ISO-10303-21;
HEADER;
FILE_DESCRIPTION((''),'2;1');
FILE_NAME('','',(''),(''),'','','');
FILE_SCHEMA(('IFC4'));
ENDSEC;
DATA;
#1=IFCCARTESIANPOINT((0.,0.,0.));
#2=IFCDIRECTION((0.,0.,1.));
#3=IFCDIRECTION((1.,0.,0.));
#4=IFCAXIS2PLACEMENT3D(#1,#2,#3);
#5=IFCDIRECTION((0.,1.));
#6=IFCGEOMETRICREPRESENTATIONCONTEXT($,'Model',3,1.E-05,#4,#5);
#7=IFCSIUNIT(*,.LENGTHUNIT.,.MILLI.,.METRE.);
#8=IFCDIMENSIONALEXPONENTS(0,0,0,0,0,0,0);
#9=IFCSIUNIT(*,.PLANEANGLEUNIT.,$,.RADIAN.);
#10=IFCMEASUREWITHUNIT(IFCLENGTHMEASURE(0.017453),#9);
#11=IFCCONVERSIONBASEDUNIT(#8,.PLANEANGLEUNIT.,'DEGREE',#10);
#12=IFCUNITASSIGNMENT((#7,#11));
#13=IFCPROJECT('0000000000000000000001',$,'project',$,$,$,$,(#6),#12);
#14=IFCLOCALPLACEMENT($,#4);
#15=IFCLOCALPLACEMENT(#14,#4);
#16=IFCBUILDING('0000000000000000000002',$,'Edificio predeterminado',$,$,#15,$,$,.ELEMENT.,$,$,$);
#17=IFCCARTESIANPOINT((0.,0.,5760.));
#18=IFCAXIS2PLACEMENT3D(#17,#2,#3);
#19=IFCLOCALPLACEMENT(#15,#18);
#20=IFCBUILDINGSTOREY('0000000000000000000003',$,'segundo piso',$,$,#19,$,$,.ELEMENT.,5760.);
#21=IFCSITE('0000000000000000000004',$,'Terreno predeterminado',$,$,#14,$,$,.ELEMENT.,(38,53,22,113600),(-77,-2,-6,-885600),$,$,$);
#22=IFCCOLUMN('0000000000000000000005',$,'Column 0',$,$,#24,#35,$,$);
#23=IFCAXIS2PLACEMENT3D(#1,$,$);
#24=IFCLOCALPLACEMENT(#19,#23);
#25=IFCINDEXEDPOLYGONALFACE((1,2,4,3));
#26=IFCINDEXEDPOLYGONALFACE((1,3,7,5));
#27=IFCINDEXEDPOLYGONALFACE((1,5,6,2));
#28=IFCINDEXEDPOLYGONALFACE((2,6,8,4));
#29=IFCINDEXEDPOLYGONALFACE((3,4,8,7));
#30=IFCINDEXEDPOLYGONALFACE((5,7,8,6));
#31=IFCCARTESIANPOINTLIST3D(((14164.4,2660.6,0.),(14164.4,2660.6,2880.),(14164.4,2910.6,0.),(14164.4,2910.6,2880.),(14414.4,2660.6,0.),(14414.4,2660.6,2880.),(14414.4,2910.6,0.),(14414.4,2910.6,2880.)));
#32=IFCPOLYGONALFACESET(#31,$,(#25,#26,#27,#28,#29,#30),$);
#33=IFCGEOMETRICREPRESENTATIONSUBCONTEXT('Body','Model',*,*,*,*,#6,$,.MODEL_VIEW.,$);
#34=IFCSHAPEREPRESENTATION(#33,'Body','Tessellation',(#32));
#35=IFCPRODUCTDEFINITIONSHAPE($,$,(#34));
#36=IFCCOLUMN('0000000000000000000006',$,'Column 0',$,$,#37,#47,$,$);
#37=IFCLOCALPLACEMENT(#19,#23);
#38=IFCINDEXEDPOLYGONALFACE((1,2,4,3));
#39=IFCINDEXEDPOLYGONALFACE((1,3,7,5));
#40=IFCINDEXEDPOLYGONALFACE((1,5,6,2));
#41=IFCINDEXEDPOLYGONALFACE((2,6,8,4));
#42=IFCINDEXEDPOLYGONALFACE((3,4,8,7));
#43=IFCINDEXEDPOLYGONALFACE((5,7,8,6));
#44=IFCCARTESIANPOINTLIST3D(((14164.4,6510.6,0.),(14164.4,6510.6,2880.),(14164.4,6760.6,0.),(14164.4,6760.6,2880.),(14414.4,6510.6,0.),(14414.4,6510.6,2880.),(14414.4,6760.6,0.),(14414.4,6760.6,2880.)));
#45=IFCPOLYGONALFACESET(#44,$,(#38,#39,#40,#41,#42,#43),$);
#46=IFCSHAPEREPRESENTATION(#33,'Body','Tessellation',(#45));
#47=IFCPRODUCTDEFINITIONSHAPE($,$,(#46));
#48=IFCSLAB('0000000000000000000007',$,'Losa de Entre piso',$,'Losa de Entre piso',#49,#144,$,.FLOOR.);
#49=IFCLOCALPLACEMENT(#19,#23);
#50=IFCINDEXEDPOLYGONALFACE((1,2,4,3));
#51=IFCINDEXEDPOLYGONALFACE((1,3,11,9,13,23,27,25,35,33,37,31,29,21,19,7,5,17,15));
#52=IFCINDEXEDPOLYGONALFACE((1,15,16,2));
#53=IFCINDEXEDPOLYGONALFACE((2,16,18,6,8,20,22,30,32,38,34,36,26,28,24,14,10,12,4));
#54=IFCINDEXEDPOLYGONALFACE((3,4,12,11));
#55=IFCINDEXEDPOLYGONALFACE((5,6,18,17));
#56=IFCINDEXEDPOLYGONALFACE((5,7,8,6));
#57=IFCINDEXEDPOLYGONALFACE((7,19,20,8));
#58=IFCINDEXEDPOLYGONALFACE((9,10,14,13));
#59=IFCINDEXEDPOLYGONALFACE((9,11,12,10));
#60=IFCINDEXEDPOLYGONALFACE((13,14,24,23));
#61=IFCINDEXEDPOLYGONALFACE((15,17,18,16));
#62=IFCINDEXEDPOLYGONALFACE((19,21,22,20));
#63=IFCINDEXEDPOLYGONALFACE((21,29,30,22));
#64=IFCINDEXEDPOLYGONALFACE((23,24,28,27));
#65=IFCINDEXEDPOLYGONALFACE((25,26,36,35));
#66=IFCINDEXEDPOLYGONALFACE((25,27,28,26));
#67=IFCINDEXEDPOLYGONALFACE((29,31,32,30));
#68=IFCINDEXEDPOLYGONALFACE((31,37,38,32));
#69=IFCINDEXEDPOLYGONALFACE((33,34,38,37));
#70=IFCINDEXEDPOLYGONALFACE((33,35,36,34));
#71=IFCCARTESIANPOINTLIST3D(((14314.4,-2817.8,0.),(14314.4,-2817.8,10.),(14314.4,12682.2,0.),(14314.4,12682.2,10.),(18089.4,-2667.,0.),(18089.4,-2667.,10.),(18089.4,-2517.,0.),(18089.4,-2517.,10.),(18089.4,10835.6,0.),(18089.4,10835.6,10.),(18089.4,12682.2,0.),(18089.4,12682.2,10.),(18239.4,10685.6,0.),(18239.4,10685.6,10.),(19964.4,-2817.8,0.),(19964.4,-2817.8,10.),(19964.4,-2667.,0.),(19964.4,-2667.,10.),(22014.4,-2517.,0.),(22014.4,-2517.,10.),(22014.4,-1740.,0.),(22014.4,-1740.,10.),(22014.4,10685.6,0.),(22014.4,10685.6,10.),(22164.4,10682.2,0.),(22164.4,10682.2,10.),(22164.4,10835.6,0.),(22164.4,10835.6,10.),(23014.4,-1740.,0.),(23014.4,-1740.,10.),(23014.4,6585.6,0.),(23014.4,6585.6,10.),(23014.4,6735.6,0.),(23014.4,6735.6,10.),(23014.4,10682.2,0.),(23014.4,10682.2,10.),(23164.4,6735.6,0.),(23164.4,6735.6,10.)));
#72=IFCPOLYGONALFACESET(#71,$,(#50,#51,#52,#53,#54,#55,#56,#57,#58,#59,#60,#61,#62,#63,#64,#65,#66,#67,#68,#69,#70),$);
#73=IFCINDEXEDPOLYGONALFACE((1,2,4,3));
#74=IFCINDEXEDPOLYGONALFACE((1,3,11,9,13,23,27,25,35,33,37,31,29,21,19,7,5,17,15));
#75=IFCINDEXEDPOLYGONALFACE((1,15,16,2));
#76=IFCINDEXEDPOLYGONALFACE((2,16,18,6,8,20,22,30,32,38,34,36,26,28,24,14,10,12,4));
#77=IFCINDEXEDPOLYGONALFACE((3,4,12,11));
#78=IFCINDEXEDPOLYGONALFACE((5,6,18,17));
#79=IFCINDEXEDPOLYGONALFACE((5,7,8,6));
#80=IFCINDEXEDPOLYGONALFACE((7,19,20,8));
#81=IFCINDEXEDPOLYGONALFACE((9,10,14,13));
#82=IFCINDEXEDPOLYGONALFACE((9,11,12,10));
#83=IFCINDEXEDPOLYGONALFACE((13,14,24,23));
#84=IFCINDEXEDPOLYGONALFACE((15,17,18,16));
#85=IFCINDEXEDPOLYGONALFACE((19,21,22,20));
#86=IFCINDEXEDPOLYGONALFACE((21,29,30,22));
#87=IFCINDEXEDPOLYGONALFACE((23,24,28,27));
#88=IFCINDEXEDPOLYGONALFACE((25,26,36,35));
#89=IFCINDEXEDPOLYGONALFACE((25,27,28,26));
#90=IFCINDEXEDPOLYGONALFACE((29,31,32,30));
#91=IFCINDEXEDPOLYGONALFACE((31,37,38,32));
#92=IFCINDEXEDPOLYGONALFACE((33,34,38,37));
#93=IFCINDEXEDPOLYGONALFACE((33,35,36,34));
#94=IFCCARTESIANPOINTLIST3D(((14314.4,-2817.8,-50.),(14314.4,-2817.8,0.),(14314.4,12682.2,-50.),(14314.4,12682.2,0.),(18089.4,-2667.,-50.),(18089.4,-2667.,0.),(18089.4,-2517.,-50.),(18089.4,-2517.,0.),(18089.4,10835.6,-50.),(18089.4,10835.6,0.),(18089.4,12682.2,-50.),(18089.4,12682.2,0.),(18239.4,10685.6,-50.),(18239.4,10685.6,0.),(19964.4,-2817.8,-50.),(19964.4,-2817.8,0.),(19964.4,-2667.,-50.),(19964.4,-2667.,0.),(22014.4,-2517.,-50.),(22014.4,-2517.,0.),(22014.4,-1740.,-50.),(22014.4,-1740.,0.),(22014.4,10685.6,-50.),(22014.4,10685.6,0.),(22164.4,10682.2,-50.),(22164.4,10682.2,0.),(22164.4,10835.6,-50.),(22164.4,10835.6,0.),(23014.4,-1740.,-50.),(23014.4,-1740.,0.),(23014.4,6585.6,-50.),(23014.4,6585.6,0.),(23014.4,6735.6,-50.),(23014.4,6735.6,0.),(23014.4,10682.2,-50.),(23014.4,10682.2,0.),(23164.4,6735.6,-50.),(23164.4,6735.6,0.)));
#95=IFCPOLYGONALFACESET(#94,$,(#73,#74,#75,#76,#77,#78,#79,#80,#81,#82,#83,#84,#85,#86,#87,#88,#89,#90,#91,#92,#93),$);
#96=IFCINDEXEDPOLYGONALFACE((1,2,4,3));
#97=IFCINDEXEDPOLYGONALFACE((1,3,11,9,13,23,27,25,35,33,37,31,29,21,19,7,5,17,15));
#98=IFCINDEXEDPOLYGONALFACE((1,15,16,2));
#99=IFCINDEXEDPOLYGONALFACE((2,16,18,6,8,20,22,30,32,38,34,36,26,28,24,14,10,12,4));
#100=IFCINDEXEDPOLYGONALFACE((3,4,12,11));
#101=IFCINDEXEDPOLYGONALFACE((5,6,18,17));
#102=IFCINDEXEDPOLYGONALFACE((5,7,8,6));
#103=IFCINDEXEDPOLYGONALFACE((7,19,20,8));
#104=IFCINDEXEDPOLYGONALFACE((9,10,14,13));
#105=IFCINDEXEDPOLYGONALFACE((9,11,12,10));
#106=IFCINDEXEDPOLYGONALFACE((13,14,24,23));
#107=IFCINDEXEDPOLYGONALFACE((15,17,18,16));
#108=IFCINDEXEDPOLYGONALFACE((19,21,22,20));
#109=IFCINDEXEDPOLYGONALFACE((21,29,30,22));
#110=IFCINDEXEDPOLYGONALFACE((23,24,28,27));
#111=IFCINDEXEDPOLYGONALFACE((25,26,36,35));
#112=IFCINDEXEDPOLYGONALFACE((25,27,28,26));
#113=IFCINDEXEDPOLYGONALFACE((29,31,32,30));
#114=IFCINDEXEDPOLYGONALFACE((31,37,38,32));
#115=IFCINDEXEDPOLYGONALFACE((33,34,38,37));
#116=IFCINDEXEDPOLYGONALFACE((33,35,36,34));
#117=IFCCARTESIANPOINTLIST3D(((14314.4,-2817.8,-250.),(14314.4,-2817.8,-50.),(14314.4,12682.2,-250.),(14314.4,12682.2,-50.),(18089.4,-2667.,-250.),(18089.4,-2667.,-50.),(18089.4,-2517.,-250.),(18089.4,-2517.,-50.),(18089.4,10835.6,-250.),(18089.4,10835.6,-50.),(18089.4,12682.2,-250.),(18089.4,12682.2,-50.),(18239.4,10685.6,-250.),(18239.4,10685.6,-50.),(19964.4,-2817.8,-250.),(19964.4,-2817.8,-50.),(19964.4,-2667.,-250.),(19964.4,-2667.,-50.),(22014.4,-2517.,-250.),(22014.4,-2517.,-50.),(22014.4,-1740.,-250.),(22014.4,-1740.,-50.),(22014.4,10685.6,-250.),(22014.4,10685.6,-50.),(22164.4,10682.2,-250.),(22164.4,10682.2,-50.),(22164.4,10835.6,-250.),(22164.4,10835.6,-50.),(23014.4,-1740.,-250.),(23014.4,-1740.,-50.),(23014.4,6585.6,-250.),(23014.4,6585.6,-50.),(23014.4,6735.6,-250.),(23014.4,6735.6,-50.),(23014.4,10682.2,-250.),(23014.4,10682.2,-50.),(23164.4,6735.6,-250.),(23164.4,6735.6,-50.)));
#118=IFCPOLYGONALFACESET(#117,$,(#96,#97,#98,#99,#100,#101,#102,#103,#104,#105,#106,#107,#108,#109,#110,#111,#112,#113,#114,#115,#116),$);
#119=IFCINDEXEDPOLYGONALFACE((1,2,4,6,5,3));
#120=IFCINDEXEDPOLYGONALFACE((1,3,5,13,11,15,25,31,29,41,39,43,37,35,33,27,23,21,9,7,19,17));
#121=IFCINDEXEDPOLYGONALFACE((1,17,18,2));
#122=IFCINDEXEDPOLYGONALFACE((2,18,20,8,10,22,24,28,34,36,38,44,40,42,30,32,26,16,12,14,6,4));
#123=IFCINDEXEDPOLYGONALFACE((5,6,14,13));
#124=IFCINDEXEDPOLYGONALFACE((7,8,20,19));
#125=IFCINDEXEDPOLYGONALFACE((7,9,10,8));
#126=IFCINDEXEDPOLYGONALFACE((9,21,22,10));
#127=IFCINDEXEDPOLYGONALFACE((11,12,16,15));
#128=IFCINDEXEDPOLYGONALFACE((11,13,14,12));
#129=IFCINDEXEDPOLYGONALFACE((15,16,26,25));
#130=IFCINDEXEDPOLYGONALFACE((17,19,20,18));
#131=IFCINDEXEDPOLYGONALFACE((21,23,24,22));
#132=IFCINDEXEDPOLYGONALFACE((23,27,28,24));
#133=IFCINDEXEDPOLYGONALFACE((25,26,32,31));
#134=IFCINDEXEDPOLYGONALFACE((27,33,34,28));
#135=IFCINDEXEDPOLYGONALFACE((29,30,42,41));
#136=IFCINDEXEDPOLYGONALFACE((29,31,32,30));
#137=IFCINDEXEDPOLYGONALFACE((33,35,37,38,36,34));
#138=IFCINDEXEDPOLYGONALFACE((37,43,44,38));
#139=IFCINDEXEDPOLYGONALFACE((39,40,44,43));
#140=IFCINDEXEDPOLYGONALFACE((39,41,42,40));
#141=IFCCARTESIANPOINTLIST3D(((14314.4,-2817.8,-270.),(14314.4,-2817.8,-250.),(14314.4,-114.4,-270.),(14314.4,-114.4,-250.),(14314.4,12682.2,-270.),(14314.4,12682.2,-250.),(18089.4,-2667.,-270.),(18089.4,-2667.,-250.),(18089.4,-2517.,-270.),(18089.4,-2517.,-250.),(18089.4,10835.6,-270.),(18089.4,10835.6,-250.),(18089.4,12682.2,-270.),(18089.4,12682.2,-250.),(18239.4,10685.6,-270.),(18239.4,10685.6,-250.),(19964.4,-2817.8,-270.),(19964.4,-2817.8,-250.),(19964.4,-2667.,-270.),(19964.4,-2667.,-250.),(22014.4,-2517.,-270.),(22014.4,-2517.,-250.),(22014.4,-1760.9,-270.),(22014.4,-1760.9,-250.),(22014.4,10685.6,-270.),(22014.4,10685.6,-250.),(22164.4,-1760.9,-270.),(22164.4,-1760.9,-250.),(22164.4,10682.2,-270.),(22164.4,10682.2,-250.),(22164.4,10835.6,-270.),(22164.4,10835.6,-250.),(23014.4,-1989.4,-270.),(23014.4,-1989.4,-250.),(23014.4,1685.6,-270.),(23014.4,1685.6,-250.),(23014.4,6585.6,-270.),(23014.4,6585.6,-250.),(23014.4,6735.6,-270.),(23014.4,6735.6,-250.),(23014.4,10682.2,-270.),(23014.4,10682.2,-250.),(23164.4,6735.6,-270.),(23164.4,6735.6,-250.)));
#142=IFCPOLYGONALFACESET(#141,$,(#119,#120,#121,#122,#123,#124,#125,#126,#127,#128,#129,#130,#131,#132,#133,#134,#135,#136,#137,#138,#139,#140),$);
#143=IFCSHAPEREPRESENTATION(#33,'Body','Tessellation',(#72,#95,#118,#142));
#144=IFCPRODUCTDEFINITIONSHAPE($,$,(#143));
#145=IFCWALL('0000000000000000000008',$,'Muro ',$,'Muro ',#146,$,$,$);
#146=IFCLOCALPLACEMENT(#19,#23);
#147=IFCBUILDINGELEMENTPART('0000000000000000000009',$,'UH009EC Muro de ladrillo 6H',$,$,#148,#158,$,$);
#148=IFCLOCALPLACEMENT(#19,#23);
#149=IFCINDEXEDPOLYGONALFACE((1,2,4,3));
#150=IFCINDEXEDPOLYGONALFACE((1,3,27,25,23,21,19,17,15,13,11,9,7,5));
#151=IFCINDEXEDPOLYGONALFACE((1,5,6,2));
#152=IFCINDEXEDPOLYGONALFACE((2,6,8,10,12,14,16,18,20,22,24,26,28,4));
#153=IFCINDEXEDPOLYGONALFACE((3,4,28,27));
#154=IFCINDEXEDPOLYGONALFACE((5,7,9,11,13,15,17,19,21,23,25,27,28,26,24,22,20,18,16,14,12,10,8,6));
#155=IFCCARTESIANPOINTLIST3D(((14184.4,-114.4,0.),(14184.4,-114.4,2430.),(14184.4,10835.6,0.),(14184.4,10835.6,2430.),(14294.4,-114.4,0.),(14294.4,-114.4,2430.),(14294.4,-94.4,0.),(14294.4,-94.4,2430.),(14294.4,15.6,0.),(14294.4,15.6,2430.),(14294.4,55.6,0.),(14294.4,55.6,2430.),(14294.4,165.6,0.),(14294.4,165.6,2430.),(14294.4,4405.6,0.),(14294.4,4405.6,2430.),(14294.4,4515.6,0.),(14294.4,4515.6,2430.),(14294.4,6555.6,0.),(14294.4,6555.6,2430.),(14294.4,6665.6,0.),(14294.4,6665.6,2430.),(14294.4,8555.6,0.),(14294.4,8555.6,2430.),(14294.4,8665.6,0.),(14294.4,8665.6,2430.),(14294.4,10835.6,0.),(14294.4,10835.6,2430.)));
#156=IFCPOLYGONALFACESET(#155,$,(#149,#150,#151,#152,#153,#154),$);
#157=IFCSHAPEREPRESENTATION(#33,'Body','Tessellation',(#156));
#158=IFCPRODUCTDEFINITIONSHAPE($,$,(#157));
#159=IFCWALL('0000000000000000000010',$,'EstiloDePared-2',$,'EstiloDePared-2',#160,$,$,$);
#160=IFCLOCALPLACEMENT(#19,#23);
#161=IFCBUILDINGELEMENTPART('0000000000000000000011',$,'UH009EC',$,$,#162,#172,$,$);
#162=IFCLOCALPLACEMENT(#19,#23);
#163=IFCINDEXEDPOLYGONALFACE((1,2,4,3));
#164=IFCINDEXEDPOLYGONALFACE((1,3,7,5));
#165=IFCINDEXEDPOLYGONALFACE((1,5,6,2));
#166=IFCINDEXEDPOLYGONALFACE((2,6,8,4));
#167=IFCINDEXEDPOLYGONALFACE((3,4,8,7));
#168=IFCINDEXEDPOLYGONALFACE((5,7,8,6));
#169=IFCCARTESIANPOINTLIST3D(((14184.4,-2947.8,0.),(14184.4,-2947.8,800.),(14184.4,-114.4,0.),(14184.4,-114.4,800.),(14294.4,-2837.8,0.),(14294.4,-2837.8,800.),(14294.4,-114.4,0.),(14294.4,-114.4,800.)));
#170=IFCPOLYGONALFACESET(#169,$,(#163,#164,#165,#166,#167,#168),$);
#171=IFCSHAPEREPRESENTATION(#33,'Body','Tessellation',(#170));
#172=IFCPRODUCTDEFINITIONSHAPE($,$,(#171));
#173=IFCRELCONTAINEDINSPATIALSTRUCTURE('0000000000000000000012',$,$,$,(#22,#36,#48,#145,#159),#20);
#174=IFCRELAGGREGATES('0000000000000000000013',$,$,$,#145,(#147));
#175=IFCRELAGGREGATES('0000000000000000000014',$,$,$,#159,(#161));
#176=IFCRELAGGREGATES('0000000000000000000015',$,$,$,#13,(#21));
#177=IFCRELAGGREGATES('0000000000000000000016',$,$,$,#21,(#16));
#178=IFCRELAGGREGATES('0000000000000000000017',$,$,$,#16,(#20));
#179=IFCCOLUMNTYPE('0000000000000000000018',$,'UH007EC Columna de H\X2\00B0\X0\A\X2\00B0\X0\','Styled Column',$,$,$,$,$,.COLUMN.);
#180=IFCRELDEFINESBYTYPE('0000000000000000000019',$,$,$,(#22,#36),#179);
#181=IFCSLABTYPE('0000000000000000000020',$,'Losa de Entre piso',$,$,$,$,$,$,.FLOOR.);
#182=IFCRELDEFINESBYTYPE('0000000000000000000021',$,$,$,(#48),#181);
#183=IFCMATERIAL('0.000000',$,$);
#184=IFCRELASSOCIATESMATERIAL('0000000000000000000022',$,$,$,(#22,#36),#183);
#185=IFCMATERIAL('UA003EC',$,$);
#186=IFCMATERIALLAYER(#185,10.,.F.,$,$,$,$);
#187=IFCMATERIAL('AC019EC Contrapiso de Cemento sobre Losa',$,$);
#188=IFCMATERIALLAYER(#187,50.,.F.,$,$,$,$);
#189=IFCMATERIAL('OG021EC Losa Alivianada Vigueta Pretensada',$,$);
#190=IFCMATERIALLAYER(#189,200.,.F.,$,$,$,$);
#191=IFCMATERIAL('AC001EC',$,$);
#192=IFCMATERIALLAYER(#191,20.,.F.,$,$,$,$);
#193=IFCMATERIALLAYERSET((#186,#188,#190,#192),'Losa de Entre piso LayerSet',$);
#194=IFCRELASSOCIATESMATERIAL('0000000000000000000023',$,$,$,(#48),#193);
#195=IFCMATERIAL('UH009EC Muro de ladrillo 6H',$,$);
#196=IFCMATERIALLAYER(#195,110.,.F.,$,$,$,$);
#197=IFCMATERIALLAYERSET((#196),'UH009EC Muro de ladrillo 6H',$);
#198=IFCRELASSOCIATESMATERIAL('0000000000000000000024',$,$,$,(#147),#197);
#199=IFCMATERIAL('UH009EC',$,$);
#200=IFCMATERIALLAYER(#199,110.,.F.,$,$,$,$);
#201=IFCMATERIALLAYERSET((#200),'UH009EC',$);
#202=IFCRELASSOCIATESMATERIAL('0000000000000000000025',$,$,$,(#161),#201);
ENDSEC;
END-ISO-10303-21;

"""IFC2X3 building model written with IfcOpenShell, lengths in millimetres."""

from ifc_helpers import new_model, entity, si_unit, converted_unit, direction, frame, origin_with_axes, place, context, subcontext, project, spatial, polyline, outline, extrude, material, layer, layer_set, layer_usage, type_object, element, aggregate, save


model = new_model("IFC2X3")

# Units and contexts
model_context = context("Model", 3, precision=1e-05, world=origin_with_axes(), true_north=direction((0.0, 1.0)))
body_context = subcontext(model_context, "Body", "Model", "MODEL_VIEW")
ifc_project = project(units=[si_unit("LENGTHUNIT", "METRE", prefix="MILLI"), converted_unit("PLANEANGLEUNIT", "DEGREE", entity("IfcLengthMeasure", 0.017453), si_unit("PLANEANGLEUNIT", "RADIAN"), dimensions=[0, 0, 0, 0, 0, 0, 0])], contexts=[model_context])

# Site, building, storey
site_placement = place(None, origin_with_axes())
site = spatial("IfcSite", under=ifc_project, at=site_placement, Name="Terreno predeterminado", CompositionType="ELEMENT", RefLatitude=(38, 53, 22, 113600), RefLongitude=(-77, -2, -6, -885600))
building_placement = place(site_placement, origin_with_axes())
building = spatial("IfcBuilding", under=site, at=building_placement, Name="Edificio predeterminado", CompositionType="ELEMENT")
storey_placement = place(building_placement, frame((0.0, 0.0, 5760.0), z_axis=(0.0, 0.0, 1.0), x_axis=(1.0, 0.0, 0.0)))
storey = spatial("IfcBuildingStorey", under=building, at=storey_placement, Name="segundo piso", CompositionType="ELEMENT", Elevation=5760.0)

# Columns
ifc_material_1 = material(Name="0.000000")
column_type = type_object("IfcColumnType", Name="UH007EC Columna de H°A°", Description="Styled Column", PredefinedType="COLUMN")
for number, where, z_axis, x_axis, name in (
    (1, (14289.4, 2785.6, 0.0), (0.0, 0.0, 1.0), (1.0, 0.0, 0.0), "Column 0"),
    (2, (14289.4, 6635.6, 0.0), (0.0, 0.0, 1.0), (1.0, 0.0, 0.0), "Column 0"),
):
    element("IfcColumn", number, at=place(storey_placement, frame(where, z_axis=z_axis, x_axis=x_axis)), inside=storey, type_object=column_type, material=ifc_material_1, Name=name, context=body_context, shape_type="SweptSolid", body=[
        extrude(outline(polyline([(-125.0, -125.0), (125.0, -125.0), (125.0, 125.0), (-125.0, 125.0), (-125.0, -125.0)])), origin_with_axes(), (0.0, 0.0, 1.0), 2880.0),
    ])

# Slab
ifc_material_2 = material(Name="UA003EC")
ifc_layer_1 = layer(ifc_material_2, 10.0, ventilated=False)
ifc_material_3 = material(Name="AC019EC Contrapiso de Cemento sobre Losa")
ifc_layer_2 = layer(ifc_material_3, 50.0, ventilated=False)
ifc_material_4 = material(Name="OG021EC Losa Alivianada Vigueta Pretensada")
ifc_layer_3 = layer(ifc_material_4, 200.0, ventilated=False)
ifc_material_5 = material(Name="AC001EC")
ifc_layer_4 = layer(ifc_material_5, 20.0, ventilated=False)
ifc_layer_set_1 = layer_set([ifc_layer_1, ifc_layer_2, ifc_layer_3, ifc_layer_4], Name="Losa de Entre piso LayerSet")
ifc_layer_usage_1 = layer_usage(ifc_layer_set_1, "AXIS3", "POSITIVE", 0.0)
slab_type = type_object("IfcSlabType", Name="Losa de Entre piso", PredefinedType="FLOOR")
slab_placement = place(storey_placement, frame((0.0, 0.0, -5760.0), z_axis=(0.0, 0.0, 1.0), x_axis=(1.0, 0.0, 0.0)))
element("IfcSlab", 3, at=slab_placement, inside=storey, type_object=slab_type, material=ifc_layer_usage_1, Name="Losa de Entre piso", ObjectType="Losa de Entre piso", PredefinedType="FLOOR", context=body_context, shape_type="SweptSolid", body=[
    extrude(outline(polyline([(0.0, -777.0), (-1000.0, -777.0), (-1000.0, -9102.6), (-1150.0, -9252.6), (-1000.0, -9252.6), (-1000.0, -13199.1), (-150.0, -13199.1), (-150.0, -13352.6), (0.0, -13202.6), (3775.0, -13202.6), (3925.0, -13352.6), (3925.0, -15199.1), (7700.0, -15199.1), (7700.0, 300.9), (2050.0, 300.9), (2050.0, 150.0), (3925.0, 150.0), (3925.0, 0.0), (0.0, 0.0), (0.0, -777.0)])), frame((22014.4, -2517.0, 5760.0), z_axis=(0.0, 0.0, 1.0), x_axis=(-1.0, 0.0, 0.0)), (0.0, 0.0, 1.0), 10.0),
    extrude(outline(polyline([(0.0, -777.0), (-1000.0, -777.0), (-1000.0, -9102.6), (-1150.0, -9252.6), (-1000.0, -9252.6), (-1000.0, -13199.1), (-150.0, -13199.1), (-150.0, -13352.6), (0.0, -13202.6), (3775.0, -13202.6), (3925.0, -13352.6), (3925.0, -15199.1), (7700.0, -15199.1), (7700.0, 300.9), (2050.0, 300.9), (2050.0, 150.0), (3925.0, 150.0), (3925.0, 0.0), (0.0, 0.0), (0.0, -777.0)])), frame((22014.4, -2517.0, 5710.0), z_axis=(0.0, 0.0, 1.0), x_axis=(-1.0, 0.0, 0.0)), (0.0, 0.0, 1.0), 50.0),
    extrude(outline(polyline([(0.0, -777.0), (-1000.0, -777.0), (-1000.0, -9102.6), (-1150.0, -9252.6), (-1000.0, -9252.6), (-1000.0, -13199.1), (-150.0, -13199.1), (-150.0, -13352.6), (0.0, -13202.6), (3775.0, -13202.6), (3925.0, -13352.6), (3925.0, -15199.1), (7700.0, -15199.1), (7700.0, 300.9), (2050.0, 300.9), (2050.0, 150.0), (3925.0, 150.0), (3925.0, 0.0), (0.0, 0.0), (0.0, -777.0)])), frame((22014.4, -2517.0, 5510.0), z_axis=(0.0, 0.0, 1.0), x_axis=(-1.0, 0.0, 0.0)), (0.0, 0.0, 1.0), 200.0),
    extrude(outline(polyline([(-1305.7, 1305.7), (-3975.1, -1363.6), (5073.5, -10412.1), (6985.1, -12323.8), (10980.3, -8328.6), (10873.6, -8221.9), (9547.8, -9547.8), (9441.7, -9441.7), (12217.1, -6666.3), (11682.5, -6131.7), (11788.6, -6025.7), (12551.1, -5586.1), (9952.5, -2987.5), (6487.7, 477.3), (6487.7, 689.4), (6381.6, 583.4), (3591.0, 3374.0), (2990.0, 2773.0), (2881.5, 2881.5), (2881.5, 2669.3), (212.1, 0.0), (0.0, 0.0), (-1305.7, 1305.7)])), frame((18089.4, 10835.6, 5490.0), z_axis=(0.0, 0.0, 1.0), x_axis=(0.707107, -0.707107, 0.0)), (0.0, 0.0, 1.0), 20.0),
])

# Walls, building element parts
wall_1_placement = place(storey_placement, frame((14239.4, 10835.6, 0.0), z_axis=(0.0, 0.0, 1.0), x_axis=(0.0, -1.0, 0.0)))
wall_1 = element("IfcWall", 4, at=wall_1_placement, inside=storey, Name="Muro ", ObjectType="Muro ")
ifc_material_6 = material(Name="UH009EC Muro de ladrillo 6H")
ifc_layer_5 = layer(ifc_material_6, 110.0, ventilated=False)
ifc_layer_set_2 = layer_set([ifc_layer_5], Name="UH009EC Muro de ladrillo 6H")
ifc_layer_usage_2 = layer_usage(ifc_layer_set_2, "AXIS2", "NEGATIVE", -55.0)
building_element_part_1_placement = place(wall_1_placement, origin_with_axes())
building_element_part_1 = element("IfcBuildingElementPart", 5, at=building_element_part_1_placement, material=ifc_layer_usage_2, Name="UH009EC Muro de ladrillo 6H", context=body_context, shape_type="SweptSolid", body=[
    extrude(outline(polyline([(4280.0, 55.0), (6320.0, 55.0), (6430.0, 55.0), (10670.0, 55.0), (10780.0, 55.0), (10820.0, 55.0), (10930.0, 55.0), (10950.0, 55.0), (10950.0, -55.0), (0.0, -55.0), (0.0, 55.0), (2170.0, 55.0), (2280.0, 55.0), (4170.0, 55.0), (4280.0, 55.0)])), origin_with_axes(), (0.0, 0.0, 1.0), 2430.0),
])
aggregate(wall_1, [building_element_part_1])
wall_2_placement = place(storey_placement, frame((14239.4, -2892.8, 0.0), z_axis=(0.0, 0.0, 1.0), x_axis=(0.0, 1.0, 0.0)))
wall_2 = element("IfcWall", 6, at=wall_2_placement, inside=storey, Name="EstiloDePared-2", ObjectType="EstiloDePared-2")
ifc_material_7 = material(Name="UH009EC")
ifc_layer_6 = layer(ifc_material_7, 110.0, ventilated=False)
ifc_layer_set_3 = layer_set([ifc_layer_6], Name="UH009EC")
ifc_layer_usage_3 = layer_usage(ifc_layer_set_3, "AXIS2", "NEGATIVE", -55.0)
building_element_part_2_placement = place(wall_2_placement, origin_with_axes())
building_element_part_2 = element("IfcBuildingElementPart", 7, at=building_element_part_2_placement, material=ifc_layer_usage_3, Name="UH009EC", context=body_context, shape_type="SweptSolid", body=[
    extrude(outline(polyline([(2778.4, 55.0), (2778.4, -55.0), (55.0, -55.0), (-55.0, 55.0), (2778.4, 55.0)])), origin_with_axes(), (0.0, 0.0, 1.0), 800.0),
])
aggregate(wall_2, [building_element_part_2])

save(model, "model.ifc")
